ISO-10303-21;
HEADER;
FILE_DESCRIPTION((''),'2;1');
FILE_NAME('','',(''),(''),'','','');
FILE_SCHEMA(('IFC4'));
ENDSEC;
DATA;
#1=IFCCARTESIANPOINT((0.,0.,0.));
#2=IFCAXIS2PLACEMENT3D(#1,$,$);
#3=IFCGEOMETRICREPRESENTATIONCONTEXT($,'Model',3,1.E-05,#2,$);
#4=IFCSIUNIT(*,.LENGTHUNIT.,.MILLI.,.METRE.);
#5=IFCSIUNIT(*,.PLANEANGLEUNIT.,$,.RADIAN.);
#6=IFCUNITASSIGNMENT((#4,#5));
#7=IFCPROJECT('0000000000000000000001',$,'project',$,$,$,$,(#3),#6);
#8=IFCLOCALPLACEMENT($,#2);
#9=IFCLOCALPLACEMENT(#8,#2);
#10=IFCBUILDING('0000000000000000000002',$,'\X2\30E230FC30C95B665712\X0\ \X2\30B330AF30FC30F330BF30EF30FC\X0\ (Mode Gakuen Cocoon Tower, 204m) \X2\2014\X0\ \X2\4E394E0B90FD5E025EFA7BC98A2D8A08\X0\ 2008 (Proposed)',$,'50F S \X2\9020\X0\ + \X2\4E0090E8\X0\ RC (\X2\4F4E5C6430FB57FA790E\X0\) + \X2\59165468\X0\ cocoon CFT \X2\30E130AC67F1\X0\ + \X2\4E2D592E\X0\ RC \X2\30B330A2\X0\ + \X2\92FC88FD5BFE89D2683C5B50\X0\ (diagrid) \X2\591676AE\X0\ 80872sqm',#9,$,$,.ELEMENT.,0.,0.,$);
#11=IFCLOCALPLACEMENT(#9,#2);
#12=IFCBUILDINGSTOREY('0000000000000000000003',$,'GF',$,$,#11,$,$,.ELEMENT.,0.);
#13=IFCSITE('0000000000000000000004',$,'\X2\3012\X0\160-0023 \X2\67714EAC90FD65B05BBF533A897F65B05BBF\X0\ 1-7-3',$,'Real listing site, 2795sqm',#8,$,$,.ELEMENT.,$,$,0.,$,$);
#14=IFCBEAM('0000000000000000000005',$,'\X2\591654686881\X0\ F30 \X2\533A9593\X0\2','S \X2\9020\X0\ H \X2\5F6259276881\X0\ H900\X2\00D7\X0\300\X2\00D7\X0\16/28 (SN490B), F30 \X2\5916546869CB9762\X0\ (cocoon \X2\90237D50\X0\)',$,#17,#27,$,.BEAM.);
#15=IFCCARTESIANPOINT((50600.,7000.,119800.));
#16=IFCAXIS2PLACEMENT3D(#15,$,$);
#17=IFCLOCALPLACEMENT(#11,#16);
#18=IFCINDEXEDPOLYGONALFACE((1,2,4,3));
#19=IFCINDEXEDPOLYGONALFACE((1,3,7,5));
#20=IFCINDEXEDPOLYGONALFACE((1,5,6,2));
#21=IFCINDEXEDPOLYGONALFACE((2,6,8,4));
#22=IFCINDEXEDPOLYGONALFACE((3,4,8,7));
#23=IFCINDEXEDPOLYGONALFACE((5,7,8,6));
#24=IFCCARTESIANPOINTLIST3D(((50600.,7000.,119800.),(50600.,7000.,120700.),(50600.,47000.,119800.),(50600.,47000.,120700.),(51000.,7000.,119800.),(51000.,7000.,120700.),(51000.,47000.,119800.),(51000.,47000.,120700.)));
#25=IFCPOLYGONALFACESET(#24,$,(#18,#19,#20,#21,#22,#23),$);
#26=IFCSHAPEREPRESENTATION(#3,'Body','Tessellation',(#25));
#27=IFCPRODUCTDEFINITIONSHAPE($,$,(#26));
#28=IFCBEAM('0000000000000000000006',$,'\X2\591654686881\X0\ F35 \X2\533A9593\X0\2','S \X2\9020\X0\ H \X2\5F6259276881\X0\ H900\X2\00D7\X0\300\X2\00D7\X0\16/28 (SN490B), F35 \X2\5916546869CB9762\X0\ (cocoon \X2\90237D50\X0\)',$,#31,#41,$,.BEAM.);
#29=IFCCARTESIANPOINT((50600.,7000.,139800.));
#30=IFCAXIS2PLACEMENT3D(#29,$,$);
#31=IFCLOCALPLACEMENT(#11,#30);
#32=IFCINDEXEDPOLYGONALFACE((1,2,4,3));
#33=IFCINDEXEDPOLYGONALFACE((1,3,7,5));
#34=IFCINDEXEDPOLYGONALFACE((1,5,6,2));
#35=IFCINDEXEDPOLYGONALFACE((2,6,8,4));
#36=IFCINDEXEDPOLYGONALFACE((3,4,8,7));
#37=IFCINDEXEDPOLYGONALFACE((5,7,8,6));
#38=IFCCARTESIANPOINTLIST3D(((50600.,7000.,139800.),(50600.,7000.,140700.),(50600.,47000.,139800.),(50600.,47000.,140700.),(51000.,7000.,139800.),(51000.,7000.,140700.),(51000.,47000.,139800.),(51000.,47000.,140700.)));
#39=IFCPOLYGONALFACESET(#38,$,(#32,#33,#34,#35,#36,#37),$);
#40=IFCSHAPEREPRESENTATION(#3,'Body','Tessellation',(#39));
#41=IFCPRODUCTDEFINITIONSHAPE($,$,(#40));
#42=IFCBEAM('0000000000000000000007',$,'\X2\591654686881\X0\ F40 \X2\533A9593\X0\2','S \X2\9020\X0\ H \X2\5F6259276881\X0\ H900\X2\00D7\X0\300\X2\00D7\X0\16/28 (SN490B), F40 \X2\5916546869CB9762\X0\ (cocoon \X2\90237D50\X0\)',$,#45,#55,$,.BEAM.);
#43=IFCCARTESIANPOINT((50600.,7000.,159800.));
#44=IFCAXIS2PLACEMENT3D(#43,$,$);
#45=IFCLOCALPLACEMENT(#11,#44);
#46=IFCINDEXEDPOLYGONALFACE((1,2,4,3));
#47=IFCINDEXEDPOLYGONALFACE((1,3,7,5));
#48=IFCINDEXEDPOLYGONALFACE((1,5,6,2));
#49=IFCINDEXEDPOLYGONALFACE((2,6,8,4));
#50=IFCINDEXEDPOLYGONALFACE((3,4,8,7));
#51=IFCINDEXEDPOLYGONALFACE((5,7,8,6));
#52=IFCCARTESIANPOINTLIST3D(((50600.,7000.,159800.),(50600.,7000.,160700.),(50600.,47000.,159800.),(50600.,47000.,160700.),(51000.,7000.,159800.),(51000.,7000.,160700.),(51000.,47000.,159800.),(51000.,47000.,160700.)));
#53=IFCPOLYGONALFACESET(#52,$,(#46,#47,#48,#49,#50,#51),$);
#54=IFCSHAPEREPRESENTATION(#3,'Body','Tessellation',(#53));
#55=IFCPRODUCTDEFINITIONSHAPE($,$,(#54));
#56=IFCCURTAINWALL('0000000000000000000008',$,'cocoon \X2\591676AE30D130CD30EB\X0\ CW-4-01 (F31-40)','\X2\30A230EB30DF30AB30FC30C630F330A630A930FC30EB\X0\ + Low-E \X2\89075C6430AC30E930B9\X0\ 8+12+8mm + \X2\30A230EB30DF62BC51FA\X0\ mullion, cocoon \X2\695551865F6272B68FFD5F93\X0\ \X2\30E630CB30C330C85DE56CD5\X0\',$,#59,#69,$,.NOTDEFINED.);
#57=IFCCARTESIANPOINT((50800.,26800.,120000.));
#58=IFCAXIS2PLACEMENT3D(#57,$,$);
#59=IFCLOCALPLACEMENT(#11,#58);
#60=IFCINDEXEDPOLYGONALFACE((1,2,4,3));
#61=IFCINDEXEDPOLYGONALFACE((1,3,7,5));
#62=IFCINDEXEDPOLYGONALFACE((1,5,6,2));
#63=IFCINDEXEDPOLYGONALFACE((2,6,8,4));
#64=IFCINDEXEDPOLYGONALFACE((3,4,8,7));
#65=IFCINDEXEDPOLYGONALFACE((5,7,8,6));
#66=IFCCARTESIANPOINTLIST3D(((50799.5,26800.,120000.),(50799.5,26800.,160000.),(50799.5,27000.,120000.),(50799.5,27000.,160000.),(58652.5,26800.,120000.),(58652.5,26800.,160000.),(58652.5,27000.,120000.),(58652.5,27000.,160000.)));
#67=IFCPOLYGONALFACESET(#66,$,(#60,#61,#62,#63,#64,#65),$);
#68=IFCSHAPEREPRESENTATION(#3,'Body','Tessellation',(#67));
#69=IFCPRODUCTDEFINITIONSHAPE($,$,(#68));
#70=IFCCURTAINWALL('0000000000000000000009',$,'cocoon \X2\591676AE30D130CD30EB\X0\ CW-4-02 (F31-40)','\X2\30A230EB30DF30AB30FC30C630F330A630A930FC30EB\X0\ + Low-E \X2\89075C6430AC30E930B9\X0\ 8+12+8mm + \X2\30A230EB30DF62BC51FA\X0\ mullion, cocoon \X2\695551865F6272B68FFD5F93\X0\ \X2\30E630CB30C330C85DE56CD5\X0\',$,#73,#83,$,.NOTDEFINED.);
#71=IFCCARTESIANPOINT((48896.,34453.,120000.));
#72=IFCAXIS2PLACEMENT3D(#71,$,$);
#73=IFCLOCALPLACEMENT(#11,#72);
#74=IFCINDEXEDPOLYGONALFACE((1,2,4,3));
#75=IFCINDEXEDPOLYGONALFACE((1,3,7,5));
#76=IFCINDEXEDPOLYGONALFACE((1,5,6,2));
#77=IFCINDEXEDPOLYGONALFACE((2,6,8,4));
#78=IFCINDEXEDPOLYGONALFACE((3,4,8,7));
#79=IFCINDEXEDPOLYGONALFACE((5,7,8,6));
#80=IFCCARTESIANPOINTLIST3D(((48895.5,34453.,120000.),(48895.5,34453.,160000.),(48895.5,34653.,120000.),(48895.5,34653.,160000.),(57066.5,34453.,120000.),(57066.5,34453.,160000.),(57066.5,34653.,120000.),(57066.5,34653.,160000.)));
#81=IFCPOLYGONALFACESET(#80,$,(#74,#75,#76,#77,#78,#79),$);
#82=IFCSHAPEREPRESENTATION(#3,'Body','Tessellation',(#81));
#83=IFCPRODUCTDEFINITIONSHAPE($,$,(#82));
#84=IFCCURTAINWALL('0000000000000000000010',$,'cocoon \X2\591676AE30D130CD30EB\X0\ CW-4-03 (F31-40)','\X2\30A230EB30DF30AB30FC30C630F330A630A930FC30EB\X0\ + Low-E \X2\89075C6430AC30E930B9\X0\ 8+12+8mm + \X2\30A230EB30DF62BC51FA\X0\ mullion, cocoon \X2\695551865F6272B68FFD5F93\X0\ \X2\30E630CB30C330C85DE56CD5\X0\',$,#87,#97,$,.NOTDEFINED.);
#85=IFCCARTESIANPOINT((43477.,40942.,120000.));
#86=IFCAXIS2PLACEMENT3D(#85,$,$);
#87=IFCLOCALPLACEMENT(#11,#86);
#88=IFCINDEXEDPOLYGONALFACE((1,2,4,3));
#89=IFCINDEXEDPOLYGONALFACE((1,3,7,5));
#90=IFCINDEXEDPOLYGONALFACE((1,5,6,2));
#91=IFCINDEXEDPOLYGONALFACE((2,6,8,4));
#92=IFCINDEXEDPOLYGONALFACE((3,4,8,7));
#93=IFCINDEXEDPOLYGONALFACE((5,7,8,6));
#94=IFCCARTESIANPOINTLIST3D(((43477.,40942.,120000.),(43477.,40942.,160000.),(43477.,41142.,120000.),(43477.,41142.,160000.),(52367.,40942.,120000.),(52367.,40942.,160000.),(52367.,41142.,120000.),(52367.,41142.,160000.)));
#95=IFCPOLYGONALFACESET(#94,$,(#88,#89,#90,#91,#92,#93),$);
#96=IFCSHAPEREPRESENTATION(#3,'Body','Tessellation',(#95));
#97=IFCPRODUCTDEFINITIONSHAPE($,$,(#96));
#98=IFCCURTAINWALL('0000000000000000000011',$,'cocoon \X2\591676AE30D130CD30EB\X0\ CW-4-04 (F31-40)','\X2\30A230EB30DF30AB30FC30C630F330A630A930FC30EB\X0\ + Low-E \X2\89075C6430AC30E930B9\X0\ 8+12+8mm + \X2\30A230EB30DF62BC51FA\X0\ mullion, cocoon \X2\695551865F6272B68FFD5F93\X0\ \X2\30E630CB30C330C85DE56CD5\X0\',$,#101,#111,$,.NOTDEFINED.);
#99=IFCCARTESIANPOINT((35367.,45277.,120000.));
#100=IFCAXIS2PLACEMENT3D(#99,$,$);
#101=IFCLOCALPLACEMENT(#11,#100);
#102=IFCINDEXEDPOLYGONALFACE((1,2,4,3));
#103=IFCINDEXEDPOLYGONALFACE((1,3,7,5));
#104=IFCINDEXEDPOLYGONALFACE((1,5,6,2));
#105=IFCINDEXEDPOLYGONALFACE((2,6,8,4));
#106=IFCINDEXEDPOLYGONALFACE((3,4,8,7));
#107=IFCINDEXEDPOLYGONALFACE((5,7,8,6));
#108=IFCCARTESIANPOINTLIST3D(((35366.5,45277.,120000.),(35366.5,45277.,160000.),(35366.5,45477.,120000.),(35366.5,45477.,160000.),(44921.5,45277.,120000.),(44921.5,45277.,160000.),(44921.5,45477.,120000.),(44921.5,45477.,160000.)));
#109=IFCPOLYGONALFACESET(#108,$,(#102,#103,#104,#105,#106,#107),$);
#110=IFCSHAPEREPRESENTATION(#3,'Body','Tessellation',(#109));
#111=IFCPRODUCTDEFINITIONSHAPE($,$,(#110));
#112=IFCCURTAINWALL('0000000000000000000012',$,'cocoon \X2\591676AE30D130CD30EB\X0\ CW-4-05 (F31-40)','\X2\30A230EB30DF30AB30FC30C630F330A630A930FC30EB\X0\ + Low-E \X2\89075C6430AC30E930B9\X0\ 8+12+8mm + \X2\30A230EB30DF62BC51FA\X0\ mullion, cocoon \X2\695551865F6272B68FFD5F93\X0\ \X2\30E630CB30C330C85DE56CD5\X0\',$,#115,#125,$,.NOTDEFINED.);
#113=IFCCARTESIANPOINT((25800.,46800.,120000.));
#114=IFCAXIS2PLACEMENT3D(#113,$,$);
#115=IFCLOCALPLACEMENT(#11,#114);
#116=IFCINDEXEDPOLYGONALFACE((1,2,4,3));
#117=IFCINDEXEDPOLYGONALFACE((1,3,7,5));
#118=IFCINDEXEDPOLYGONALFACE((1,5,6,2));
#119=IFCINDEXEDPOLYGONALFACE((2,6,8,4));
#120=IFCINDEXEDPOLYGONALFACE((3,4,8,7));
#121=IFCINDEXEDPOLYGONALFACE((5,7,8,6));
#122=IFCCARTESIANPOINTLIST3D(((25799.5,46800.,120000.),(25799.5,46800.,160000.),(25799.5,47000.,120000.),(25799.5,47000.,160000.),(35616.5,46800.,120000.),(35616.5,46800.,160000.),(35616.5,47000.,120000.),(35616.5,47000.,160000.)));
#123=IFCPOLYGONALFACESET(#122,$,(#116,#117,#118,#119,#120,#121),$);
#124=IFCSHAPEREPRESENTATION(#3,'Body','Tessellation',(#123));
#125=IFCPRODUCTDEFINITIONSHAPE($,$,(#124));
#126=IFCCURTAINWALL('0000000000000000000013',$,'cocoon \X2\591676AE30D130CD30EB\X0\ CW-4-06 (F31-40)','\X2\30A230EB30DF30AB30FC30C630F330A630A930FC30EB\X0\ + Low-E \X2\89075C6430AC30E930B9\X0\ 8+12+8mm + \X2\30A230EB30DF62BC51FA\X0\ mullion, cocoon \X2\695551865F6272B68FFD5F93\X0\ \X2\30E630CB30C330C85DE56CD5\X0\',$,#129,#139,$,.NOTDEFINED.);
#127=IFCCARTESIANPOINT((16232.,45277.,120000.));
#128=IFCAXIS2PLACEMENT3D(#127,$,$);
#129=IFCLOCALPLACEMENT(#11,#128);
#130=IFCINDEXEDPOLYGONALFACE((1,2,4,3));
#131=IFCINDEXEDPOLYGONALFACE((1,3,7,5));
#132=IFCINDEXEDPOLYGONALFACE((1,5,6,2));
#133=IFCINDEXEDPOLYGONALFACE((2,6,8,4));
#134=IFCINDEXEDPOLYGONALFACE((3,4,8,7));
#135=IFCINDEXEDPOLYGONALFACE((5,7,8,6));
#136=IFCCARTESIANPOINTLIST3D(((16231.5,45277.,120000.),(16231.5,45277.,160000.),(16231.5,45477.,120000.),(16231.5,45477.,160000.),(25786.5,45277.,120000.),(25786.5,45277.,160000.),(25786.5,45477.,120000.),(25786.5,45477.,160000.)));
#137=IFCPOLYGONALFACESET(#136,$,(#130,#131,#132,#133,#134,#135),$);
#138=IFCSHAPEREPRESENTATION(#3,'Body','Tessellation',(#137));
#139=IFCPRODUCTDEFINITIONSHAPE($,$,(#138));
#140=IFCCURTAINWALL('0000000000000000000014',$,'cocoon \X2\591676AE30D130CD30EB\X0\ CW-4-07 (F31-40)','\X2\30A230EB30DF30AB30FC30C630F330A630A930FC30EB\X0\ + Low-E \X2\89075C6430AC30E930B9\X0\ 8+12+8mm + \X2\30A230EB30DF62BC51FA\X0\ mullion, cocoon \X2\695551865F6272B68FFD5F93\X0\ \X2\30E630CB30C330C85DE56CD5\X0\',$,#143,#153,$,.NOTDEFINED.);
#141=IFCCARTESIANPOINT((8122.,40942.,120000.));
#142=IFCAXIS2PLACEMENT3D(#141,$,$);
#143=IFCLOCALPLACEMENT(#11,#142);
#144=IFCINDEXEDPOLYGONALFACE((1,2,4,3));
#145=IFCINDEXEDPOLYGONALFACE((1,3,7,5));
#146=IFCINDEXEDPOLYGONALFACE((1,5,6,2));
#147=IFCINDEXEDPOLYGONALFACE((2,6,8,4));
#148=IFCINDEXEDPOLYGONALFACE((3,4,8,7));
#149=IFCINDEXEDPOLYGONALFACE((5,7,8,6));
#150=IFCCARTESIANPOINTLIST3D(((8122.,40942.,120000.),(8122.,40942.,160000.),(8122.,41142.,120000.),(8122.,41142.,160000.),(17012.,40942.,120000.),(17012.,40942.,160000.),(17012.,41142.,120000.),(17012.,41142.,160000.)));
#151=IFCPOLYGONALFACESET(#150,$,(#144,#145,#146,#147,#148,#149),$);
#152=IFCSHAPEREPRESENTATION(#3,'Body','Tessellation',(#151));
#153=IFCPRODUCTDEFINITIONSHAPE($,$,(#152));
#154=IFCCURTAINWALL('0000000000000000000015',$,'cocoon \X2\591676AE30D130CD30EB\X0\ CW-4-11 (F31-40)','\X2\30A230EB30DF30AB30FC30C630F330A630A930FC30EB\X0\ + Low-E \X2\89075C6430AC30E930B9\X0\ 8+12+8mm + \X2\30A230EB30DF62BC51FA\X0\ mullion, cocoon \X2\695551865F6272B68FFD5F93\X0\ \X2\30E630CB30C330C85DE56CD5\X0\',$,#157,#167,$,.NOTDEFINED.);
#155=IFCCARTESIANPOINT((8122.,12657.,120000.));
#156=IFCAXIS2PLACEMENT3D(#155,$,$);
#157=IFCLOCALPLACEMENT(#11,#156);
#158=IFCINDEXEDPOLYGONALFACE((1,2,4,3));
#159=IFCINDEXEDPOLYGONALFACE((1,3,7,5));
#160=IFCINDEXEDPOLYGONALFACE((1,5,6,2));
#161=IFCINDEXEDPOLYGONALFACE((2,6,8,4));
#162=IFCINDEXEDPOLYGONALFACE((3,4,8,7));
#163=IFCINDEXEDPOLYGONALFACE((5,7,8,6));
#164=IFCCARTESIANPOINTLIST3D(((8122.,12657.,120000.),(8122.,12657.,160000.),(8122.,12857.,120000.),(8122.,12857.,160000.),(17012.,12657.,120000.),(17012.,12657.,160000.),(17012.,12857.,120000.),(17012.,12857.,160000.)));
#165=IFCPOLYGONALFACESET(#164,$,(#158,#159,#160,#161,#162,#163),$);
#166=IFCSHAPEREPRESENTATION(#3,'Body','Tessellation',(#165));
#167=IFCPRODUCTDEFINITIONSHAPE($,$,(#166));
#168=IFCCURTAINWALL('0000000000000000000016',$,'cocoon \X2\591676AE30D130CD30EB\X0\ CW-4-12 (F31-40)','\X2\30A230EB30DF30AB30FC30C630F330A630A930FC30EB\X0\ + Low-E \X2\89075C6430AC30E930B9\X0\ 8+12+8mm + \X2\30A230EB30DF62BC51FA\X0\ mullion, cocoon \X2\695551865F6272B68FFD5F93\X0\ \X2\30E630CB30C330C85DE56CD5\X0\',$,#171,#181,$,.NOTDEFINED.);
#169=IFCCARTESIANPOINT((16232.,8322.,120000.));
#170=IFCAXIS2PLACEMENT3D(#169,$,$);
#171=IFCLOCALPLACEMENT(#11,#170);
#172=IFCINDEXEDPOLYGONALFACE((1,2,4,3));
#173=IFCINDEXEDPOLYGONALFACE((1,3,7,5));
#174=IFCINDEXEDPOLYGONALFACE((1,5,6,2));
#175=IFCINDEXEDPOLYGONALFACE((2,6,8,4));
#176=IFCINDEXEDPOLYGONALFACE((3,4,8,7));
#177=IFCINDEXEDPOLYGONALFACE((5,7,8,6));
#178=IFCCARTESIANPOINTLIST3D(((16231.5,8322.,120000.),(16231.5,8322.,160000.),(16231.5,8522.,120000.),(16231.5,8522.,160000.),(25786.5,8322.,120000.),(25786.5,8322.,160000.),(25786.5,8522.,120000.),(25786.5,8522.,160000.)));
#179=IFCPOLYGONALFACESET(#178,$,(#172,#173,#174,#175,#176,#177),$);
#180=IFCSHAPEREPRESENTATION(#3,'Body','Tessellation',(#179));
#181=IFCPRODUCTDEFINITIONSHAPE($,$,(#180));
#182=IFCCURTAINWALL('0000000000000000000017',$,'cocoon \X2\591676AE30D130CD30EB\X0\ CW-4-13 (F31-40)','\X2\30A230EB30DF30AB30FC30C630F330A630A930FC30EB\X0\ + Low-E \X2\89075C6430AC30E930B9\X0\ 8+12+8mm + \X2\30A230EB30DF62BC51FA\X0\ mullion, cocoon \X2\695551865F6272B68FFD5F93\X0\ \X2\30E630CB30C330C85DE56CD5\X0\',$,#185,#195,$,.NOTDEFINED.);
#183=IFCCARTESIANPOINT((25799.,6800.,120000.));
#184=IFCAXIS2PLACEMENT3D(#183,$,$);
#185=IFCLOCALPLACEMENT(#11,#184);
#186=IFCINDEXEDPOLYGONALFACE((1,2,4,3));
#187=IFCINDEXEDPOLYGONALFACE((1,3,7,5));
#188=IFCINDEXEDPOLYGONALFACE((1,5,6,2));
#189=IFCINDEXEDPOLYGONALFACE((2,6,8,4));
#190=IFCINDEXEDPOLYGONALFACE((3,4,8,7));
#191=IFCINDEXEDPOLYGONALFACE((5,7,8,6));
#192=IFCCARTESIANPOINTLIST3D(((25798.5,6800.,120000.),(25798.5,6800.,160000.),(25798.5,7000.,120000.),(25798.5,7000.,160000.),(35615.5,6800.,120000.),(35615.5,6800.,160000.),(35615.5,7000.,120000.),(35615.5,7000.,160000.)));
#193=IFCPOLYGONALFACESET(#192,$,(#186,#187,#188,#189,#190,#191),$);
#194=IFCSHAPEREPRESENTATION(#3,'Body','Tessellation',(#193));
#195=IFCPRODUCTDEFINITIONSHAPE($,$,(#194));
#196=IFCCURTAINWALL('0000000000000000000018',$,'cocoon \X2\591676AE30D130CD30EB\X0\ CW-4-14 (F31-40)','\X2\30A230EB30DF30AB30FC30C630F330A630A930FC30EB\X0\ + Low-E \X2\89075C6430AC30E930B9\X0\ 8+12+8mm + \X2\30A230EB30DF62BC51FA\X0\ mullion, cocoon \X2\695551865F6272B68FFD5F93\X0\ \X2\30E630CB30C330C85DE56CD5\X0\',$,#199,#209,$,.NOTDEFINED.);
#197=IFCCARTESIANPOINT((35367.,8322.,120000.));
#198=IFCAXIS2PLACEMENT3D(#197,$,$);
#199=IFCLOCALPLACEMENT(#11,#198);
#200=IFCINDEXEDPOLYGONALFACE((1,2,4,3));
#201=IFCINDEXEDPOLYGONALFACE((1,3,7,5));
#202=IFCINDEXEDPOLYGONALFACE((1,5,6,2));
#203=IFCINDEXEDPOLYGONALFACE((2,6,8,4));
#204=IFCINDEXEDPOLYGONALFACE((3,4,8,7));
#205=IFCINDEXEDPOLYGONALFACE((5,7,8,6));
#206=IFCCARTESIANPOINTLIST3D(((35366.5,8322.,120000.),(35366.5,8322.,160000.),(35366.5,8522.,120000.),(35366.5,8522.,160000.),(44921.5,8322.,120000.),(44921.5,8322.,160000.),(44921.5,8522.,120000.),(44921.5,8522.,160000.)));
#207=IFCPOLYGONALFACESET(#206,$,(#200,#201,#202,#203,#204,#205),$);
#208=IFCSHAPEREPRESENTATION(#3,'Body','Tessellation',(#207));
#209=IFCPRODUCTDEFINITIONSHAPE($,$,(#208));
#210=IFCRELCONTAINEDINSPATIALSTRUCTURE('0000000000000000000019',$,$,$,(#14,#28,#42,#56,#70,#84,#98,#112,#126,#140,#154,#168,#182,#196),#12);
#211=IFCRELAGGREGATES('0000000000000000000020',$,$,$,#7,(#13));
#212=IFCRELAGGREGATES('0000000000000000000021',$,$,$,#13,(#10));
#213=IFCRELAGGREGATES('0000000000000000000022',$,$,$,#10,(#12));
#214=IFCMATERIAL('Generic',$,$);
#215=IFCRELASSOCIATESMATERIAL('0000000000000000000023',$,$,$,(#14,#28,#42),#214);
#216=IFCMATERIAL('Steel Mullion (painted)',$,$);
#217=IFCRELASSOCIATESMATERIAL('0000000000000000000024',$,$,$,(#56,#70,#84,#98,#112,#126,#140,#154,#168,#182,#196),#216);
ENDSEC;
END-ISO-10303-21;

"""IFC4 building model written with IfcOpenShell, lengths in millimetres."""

from ifc_helpers import new_model, si_unit, frame, frame_2d, origin, place, context, project, spatial, rectangle, extrude, material, element, save


model = new_model("IFC4")

# Units and contexts
model_context = context("Model", 3, precision=1e-05, world=origin())
ifc_project = project(units=[si_unit("LENGTHUNIT", "METRE", prefix="MILLI"), si_unit("PLANEANGLEUNIT", "RADIAN")], contexts=[model_context])

# Site, building, storey
site_placement = place(None, origin())
site = spatial("IfcSite", under=ifc_project, at=site_placement, Name="〒160-0023 東京都新宿区西新宿 1-7-3", ObjectType="Real listing site, 2795sqm", CompositionType="ELEMENT", RefElevation=0.0)
building_placement = place(site_placement, origin())
building = spatial("IfcBuilding", under=site, at=building_placement, Name="モード学園 コクーンタワー (Mode Gakuen Cocoon Tower, 204m) — 丹下都市建築設計 2008 (Proposed)", ObjectType="50F S 造 + 一部 RC (低層・基礎) + 外周 cocoon CFT メガ柱 + 中央 RC コア + 鋼製対角格子 (diagrid) 外皮 80872sqm", CompositionType="ELEMENT", ElevationOfRefHeight=0.0, ElevationOfTerrain=0.0)
storey_placement = place(building_placement, origin())
storey = spatial("IfcBuildingStorey", under=building, at=storey_placement, Name="GF", CompositionType="ELEMENT", Elevation=0.0)

# Beams
ifc_material_1 = material(Name="Generic")
beam_1_placement = place(storey_placement, frame((50600.0, 7000.0, 119800.0)))
element("IfcBeam", 1, at=beam_1_placement, inside=storey, material=ifc_material_1, Name="外周梁 F30 区間2", Description="S 造 H 形大梁 H900×300×16/28 (SN490B), F30 外周構面 (cocoon 連結)", PredefinedType="BEAM", context=model_context, shape_type="SweptSolid", body=[
    extrude(rectangle(XDim=400.0, YDim=40000.0, at=frame_2d((200.0, 20000.0))), frame((50600.0, 7000.0, 119800.0)), (0.0, 0.0, 1.0), 900.0),
])
beam_2_placement = place(storey_placement, frame((50600.0, 7000.0, 139800.0)))
element("IfcBeam", 2, at=beam_2_placement, inside=storey, material=ifc_material_1, Name="外周梁 F35 区間2", Description="S 造 H 形大梁 H900×300×16/28 (SN490B), F35 外周構面 (cocoon 連結)", PredefinedType="BEAM", context=model_context, shape_type="SweptSolid", body=[
    extrude(rectangle(XDim=400.0, YDim=40000.0, at=frame_2d((200.0, 20000.0))), frame((50600.0, 7000.0, 139800.0)), (0.0, 0.0, 1.0), 900.0),
])
beam_3_placement = place(storey_placement, frame((50600.0, 7000.0, 159800.0)))
element("IfcBeam", 3, at=beam_3_placement, inside=storey, material=ifc_material_1, Name="外周梁 F40 区間2", Description="S 造 H 形大梁 H900×300×16/28 (SN490B), F40 外周構面 (cocoon 連結)", PredefinedType="BEAM", context=model_context, shape_type="SweptSolid", body=[
    extrude(rectangle(XDim=400.0, YDim=40000.0, at=frame_2d((200.0, 20000.0))), frame((50600.0, 7000.0, 159800.0)), (0.0, 0.0, 1.0), 900.0),
])

# Curtain walls
ifc_material_2 = material(Name="Steel Mullion (painted)")
curtain_wall_1_placement = place(storey_placement, frame((50800.0, 26800.0, 120000.0)))
element("IfcCurtainWall", 4, at=curtain_wall_1_placement, inside=storey, material=ifc_material_2, Name="cocoon 外皮パネル CW-4-01 (F31-40)", Description="アルミカーテンウォール + Low-E 複層ガラス 8+12+8mm + アルミ押出 mullion, cocoon 楕円形状追従 ユニット工法", PredefinedType="NOTDEFINED", context=model_context, shape_type="SweptSolid", body=[
    extrude(rectangle(XDim=7853.0, YDim=200.0, at=frame_2d((3926.0, 100.0))), frame((50800.0, 26800.0, 120000.0)), (0.0, 0.0, 1.0), 40000.0),
])
curtain_wall_2_placement = place(storey_placement, frame((48896.0, 34453.0, 120000.0)))
element("IfcCurtainWall", 5, at=curtain_wall_2_placement, inside=storey, material=ifc_material_2, Name="cocoon 外皮パネル CW-4-02 (F31-40)", Description="アルミカーテンウォール + Low-E 複層ガラス 8+12+8mm + アルミ押出 mullion, cocoon 楕円形状追従 ユニット工法", PredefinedType="NOTDEFINED", context=model_context, shape_type="SweptSolid", body=[
    extrude(rectangle(XDim=8171.0, YDim=200.0, at=frame_2d((4085.0, 100.0))), frame((48896.0, 34453.0, 120000.0)), (0.0, 0.0, 1.0), 40000.0),
])
curtain_wall_3_placement = place(storey_placement, frame((43477.0, 40942.0, 120000.0)))
element("IfcCurtainWall", 6, at=curtain_wall_3_placement, inside=storey, material=ifc_material_2, Name="cocoon 外皮パネル CW-4-03 (F31-40)", Description="アルミカーテンウォール + Low-E 複層ガラス 8+12+8mm + アルミ押出 mullion, cocoon 楕円形状追従 ユニット工法", PredefinedType="NOTDEFINED", context=model_context, shape_type="SweptSolid", body=[
    extrude(rectangle(XDim=8890.0, YDim=200.0, at=frame_2d((4445.0, 100.0))), frame((43477.0, 40942.0, 120000.0)), (0.0, 0.0, 1.0), 40000.0),
])
curtain_wall_4_placement = place(storey_placement, frame((35367.0, 45277.0, 120000.0)))
element("IfcCurtainWall", 7, at=curtain_wall_4_placement, inside=storey, material=ifc_material_2, Name="cocoon 外皮パネル CW-4-04 (F31-40)", Description="アルミカーテンウォール + Low-E 複層ガラス 8+12+8mm + アルミ押出 mullion, cocoon 楕円形状追従 ユニット工法", PredefinedType="NOTDEFINED", context=model_context, shape_type="SweptSolid", body=[
    extrude(rectangle(XDim=9555.0, YDim=200.0, at=frame_2d((4777.0, 100.0))), frame((35367.0, 45277.0, 120000.0)), (0.0, 0.0, 1.0), 40000.0),
])
curtain_wall_5_placement = place(storey_placement, frame((25800.0, 46800.0, 120000.0)))
element("IfcCurtainWall", 8, at=curtain_wall_5_placement, inside=storey, material=ifc_material_2, Name="cocoon 外皮パネル CW-4-05 (F31-40)", Description="アルミカーテンウォール + Low-E 複層ガラス 8+12+8mm + アルミ押出 mullion, cocoon 楕円形状追従 ユニット工法", PredefinedType="NOTDEFINED", context=model_context, shape_type="SweptSolid", body=[
    extrude(rectangle(XDim=9817.0, YDim=200.0, at=frame_2d((4908.0, 100.0))), frame((25800.0, 46800.0, 120000.0)), (0.0, 0.0, 1.0), 40000.0),
])
curtain_wall_6_placement = place(storey_placement, frame((16232.0, 45277.0, 120000.0)))
element("IfcCurtainWall", 9, at=curtain_wall_6_placement, inside=storey, material=ifc_material_2, Name="cocoon 外皮パネル CW-4-06 (F31-40)", Description="アルミカーテンウォール + Low-E 複層ガラス 8+12+8mm + アルミ押出 mullion, cocoon 楕円形状追従 ユニット工法", PredefinedType="NOTDEFINED", context=model_context, shape_type="SweptSolid", body=[
    extrude(rectangle(XDim=9555.0, YDim=200.0, at=frame_2d((4777.0, 100.0))), frame((16232.0, 45277.0, 120000.0)), (0.0, 0.0, 1.0), 40000.0),
])
curtain_wall_7_placement = place(storey_placement, frame((8122.0, 40942.0, 120000.0)))
element("IfcCurtainWall", 10, at=curtain_wall_7_placement, inside=storey, material=ifc_material_2, Name="cocoon 外皮パネル CW-4-07 (F31-40)", Description="アルミカーテンウォール + Low-E 複層ガラス 8+12+8mm + アルミ押出 mullion, cocoon 楕円形状追従 ユニット工法", PredefinedType="NOTDEFINED", context=model_context, shape_type="SweptSolid", body=[
    extrude(rectangle(XDim=8890.0, YDim=200.0, at=frame_2d((4445.0, 100.0))), frame((8122.0, 40942.0, 120000.0)), (0.0, 0.0, 1.0), 40000.0),
])
curtain_wall_8_placement = place(storey_placement, frame((8122.0, 12657.0, 120000.0)))
element("IfcCurtainWall", 11, at=curtain_wall_8_placement, inside=storey, material=ifc_material_2, Name="cocoon 外皮パネル CW-4-11 (F31-40)", Description="アルミカーテンウォール + Low-E 複層ガラス 8+12+8mm + アルミ押出 mullion, cocoon 楕円形状追従 ユニット工法", PredefinedType="NOTDEFINED", context=model_context, shape_type="SweptSolid", body=[
    extrude(rectangle(XDim=8890.0, YDim=200.0, at=frame_2d((4445.0, 100.0))), frame((8122.0, 12657.0, 120000.0)), (0.0, 0.0, 1.0), 40000.0),
])
curtain_wall_9_placement = place(storey_placement, frame((16232.0, 8322.0, 120000.0)))
element("IfcCurtainWall", 12, at=curtain_wall_9_placement, inside=storey, material=ifc_material_2, Name="cocoon 外皮パネル CW-4-12 (F31-40)", Description="アルミカーテンウォール + Low-E 複層ガラス 8+12+8mm + アルミ押出 mullion, cocoon 楕円形状追従 ユニット工法", PredefinedType="NOTDEFINED", context=model_context, shape_type="SweptSolid", body=[
    extrude(rectangle(XDim=9555.0, YDim=200.0, at=frame_2d((4777.0, 100.0))), frame((16232.0, 8322.0, 120000.0)), (0.0, 0.0, 1.0), 40000.0),
])
curtain_wall_10_placement = place(storey_placement, frame((25799.0, 6800.0, 120000.0)))
element("IfcCurtainWall", 13, at=curtain_wall_10_placement, inside=storey, material=ifc_material_2, Name="cocoon 外皮パネル CW-4-13 (F31-40)", Description="アルミカーテンウォール + Low-E 複層ガラス 8+12+8mm + アルミ押出 mullion, cocoon 楕円形状追従 ユニット工法", PredefinedType="NOTDEFINED", context=model_context, shape_type="SweptSolid", body=[
    extrude(rectangle(XDim=9817.0, YDim=200.0, at=frame_2d((4908.0, 100.0))), frame((25799.0, 6800.0, 120000.0)), (0.0, 0.0, 1.0), 40000.0),
])
curtain_wall_11_placement = place(storey_placement, frame((35367.0, 8322.0, 120000.0)))
element("IfcCurtainWall", 14, at=curtain_wall_11_placement, inside=storey, material=ifc_material_2, Name="cocoon 外皮パネル CW-4-14 (F31-40)", Description="アルミカーテンウォール + Low-E 複層ガラス 8+12+8mm + アルミ押出 mullion, cocoon 楕円形状追従 ユニット工法", PredefinedType="NOTDEFINED", context=model_context, shape_type="SweptSolid", body=[
    extrude(rectangle(XDim=9555.0, YDim=200.0, at=frame_2d((4777.0, 100.0))), frame((35367.0, 8322.0, 120000.0)), (0.0, 0.0, 1.0), 40000.0),
])

save(model, "model.ifc")
